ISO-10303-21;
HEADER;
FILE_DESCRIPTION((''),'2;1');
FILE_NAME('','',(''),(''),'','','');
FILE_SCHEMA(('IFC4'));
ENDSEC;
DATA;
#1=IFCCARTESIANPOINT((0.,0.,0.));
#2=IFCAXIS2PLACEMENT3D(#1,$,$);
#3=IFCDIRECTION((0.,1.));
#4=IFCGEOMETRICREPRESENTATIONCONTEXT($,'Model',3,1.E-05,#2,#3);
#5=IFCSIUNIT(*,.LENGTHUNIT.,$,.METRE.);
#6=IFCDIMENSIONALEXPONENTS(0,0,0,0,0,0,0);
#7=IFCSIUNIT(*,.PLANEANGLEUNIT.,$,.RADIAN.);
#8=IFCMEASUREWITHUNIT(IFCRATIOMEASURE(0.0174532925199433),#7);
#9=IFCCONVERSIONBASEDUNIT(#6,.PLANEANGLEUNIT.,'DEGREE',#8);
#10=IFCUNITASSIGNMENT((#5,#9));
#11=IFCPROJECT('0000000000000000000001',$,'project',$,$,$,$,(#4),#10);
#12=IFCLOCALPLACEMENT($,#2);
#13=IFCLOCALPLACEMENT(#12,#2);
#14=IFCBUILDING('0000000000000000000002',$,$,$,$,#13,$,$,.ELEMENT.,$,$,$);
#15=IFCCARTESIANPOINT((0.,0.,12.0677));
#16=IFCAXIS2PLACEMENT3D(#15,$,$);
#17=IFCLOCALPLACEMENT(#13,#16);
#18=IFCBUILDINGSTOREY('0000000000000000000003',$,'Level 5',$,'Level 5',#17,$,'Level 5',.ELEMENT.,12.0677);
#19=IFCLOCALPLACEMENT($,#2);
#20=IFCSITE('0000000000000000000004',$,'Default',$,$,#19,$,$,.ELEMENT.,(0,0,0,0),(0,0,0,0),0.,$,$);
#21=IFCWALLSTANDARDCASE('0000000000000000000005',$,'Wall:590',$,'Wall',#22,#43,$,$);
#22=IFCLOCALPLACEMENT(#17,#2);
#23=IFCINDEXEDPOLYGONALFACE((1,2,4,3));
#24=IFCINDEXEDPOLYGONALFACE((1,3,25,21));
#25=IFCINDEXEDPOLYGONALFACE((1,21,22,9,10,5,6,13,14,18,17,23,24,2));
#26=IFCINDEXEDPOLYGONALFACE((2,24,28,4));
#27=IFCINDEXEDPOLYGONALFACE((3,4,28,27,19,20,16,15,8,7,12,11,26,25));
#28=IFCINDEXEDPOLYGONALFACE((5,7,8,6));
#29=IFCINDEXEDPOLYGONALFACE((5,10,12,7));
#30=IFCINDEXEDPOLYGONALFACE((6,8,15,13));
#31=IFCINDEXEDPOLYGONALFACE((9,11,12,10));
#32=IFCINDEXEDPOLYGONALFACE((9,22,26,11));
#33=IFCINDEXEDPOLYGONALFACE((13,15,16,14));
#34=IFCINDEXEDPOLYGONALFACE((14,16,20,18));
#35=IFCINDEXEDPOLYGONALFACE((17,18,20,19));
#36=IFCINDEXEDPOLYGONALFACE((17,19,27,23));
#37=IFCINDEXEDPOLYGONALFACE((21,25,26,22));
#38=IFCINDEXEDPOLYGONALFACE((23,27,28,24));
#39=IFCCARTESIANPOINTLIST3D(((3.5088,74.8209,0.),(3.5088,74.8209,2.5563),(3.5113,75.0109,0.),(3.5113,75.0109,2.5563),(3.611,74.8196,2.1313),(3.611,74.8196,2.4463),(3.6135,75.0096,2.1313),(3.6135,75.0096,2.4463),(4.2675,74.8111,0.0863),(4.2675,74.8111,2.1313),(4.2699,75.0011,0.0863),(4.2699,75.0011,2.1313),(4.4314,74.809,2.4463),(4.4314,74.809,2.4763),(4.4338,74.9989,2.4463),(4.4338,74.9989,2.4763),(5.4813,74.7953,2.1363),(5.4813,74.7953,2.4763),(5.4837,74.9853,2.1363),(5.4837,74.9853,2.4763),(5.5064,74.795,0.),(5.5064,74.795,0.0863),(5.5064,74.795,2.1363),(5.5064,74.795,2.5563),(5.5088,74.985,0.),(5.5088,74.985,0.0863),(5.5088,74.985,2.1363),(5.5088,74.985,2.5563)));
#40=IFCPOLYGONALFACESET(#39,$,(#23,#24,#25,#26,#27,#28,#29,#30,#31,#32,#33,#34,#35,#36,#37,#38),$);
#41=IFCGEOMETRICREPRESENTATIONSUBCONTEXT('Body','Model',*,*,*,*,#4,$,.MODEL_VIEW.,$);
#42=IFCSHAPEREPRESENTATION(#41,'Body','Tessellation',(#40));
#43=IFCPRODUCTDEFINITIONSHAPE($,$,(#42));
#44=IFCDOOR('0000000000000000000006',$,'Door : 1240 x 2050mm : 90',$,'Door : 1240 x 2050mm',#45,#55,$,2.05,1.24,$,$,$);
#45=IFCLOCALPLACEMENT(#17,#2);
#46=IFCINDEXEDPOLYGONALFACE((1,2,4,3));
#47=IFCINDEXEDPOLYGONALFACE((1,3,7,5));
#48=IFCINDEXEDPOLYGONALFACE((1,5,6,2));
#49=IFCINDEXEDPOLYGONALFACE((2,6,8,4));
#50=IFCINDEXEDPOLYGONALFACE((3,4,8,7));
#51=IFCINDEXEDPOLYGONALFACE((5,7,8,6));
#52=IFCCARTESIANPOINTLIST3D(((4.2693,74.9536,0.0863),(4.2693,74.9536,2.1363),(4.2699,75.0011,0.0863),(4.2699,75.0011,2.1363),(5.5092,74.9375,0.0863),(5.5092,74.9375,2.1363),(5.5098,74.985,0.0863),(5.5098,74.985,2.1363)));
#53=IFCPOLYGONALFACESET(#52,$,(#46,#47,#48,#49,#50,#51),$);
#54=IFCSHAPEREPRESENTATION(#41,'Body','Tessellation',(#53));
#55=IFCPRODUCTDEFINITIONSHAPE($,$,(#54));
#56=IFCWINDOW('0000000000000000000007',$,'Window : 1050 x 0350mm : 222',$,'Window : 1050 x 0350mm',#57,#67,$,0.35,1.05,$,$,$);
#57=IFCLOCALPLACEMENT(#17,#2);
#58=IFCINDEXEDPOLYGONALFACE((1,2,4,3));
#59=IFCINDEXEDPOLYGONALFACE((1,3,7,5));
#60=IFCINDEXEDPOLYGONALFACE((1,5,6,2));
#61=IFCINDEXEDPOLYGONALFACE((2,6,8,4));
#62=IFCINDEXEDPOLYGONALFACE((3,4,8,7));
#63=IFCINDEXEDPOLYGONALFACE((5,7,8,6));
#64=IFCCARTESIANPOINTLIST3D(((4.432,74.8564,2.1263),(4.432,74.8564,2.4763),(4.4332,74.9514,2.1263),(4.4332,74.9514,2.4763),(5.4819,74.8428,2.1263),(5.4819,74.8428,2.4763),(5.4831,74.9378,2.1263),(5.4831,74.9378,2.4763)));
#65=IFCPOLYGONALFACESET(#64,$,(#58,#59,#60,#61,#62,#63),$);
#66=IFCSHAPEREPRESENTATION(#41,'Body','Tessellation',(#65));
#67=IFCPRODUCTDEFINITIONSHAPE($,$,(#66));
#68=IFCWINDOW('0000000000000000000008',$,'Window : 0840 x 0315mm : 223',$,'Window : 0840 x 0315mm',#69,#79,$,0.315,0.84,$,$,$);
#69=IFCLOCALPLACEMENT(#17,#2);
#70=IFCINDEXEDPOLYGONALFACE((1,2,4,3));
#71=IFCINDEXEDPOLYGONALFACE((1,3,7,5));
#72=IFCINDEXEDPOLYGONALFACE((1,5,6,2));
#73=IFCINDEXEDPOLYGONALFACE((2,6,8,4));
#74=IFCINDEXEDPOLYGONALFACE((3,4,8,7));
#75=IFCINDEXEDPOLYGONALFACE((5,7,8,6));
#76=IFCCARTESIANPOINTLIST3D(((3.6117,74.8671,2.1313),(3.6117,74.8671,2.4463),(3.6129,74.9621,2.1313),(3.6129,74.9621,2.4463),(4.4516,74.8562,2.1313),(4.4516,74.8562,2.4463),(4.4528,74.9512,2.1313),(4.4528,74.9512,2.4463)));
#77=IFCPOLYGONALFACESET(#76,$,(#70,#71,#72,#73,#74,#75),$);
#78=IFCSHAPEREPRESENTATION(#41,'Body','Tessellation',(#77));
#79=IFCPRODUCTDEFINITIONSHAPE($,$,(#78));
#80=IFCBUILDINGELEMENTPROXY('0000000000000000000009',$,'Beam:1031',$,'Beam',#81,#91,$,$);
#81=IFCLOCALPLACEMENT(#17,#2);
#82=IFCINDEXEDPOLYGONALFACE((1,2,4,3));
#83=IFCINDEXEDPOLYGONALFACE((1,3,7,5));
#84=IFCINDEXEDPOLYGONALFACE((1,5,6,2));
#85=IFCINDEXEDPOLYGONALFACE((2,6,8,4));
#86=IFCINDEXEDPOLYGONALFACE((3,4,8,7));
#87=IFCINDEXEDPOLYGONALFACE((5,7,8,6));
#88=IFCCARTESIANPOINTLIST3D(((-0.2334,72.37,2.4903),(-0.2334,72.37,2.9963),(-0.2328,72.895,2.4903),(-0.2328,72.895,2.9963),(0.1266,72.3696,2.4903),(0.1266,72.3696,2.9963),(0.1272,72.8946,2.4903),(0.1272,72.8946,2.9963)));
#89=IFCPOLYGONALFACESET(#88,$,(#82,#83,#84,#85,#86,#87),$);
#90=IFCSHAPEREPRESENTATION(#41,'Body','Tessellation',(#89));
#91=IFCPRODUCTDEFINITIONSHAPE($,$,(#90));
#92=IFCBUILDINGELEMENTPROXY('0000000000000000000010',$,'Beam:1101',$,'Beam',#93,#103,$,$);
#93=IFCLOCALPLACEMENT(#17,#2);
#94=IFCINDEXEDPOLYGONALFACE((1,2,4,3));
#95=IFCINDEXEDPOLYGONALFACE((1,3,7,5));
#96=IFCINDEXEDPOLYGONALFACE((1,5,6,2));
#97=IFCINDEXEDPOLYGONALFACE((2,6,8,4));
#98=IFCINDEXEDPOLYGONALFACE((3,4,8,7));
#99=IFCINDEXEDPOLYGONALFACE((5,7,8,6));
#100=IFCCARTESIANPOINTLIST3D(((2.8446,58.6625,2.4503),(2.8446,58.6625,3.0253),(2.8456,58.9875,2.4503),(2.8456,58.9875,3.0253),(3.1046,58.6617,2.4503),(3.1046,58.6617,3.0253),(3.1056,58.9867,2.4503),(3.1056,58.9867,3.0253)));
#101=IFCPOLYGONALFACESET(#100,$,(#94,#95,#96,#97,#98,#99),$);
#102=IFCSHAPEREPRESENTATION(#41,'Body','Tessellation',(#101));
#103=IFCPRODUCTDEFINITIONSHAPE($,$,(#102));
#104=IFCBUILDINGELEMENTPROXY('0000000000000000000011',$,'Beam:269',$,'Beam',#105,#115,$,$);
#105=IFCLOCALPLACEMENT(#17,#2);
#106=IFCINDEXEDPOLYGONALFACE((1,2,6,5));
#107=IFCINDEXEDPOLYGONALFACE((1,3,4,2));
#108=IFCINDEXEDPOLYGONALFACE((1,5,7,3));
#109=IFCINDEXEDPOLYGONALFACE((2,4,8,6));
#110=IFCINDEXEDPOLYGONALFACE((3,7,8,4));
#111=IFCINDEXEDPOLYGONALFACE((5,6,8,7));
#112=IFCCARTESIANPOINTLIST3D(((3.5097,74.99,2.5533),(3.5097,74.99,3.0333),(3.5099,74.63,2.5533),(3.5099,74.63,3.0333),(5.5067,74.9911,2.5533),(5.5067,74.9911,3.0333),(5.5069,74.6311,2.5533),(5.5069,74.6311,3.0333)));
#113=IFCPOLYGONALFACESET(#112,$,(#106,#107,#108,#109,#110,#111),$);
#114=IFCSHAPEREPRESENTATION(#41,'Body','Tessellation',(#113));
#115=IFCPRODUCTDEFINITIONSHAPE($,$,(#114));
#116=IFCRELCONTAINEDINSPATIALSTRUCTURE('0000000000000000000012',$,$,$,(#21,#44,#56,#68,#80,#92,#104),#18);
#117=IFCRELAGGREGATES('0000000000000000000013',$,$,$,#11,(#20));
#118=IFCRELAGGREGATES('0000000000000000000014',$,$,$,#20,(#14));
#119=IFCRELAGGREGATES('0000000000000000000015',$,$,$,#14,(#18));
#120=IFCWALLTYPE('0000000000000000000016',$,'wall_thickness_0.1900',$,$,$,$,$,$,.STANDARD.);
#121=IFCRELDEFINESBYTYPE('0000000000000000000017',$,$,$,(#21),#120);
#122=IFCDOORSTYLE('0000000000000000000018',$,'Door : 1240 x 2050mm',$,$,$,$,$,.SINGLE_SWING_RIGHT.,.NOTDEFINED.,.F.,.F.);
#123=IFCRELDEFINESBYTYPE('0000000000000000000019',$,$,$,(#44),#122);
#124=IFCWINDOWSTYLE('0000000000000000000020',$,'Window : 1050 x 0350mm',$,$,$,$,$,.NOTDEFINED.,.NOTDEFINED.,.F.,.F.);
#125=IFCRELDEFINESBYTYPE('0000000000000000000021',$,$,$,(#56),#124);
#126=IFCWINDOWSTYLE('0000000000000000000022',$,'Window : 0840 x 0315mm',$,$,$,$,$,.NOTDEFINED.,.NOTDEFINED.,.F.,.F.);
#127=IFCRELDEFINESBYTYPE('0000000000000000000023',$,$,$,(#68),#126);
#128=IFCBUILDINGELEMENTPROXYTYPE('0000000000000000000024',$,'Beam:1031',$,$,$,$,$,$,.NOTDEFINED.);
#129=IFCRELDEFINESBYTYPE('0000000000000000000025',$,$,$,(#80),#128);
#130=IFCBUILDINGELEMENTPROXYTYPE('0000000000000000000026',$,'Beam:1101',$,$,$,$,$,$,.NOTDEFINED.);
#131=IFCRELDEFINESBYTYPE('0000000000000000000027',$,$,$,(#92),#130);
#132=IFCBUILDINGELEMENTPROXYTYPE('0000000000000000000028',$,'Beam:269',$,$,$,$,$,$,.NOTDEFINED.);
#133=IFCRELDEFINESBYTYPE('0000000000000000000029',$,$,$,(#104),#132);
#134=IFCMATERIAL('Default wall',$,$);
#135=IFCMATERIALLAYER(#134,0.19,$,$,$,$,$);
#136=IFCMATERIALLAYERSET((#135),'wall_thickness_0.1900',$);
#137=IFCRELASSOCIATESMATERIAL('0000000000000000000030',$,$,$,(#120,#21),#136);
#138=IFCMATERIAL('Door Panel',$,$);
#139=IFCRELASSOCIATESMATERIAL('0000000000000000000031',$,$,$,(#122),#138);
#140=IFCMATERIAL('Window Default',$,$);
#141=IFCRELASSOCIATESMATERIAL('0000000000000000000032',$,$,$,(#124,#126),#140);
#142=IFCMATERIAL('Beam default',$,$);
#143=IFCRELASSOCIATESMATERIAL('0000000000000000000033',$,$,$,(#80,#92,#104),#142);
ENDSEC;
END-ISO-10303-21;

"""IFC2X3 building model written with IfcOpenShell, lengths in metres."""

from ifc_helpers import new_model, entity, si_unit, converted_unit, direction, frame, frame_2d, origin, origin_2d_with_axis, place, context, subcontext, project, spatial, polyline, rectangle, outline, extrude, source, transform, mapped, material, layer, layer_set, layer_usage, type_object, type_shapes, element, fill, save


model = new_model("IFC2X3")

# Units and contexts
model_context = context("Model", 3, precision=1e-05, world=origin(), true_north=direction((0.0, 1.0)))
body_context = subcontext(model_context, "Body", "Model", "MODEL_VIEW")
ifc_project = project(units=[si_unit("LENGTHUNIT", "METRE"), converted_unit("PLANEANGLEUNIT", "DEGREE", entity("IfcRatioMeasure", 0.0174532925199433), si_unit("PLANEANGLEUNIT", "RADIAN"), dimensions=[0, 0, 0, 0, 0, 0, 0])], contexts=[model_context])

# Site, building, storey
site_placement = place(None, origin())
site = spatial("IfcSite", under=ifc_project, at=site_placement, Name="Default", CompositionType="ELEMENT", RefLatitude=(0, 0, 0, 0), RefLongitude=(0, 0, 0, 0), RefElevation=0.0)
placement_1 = place(None, origin())
building_placement = place(placement_1, origin())
building = spatial("IfcBuilding", under=site, at=building_placement, CompositionType="ELEMENT")
storey_placement = place(building_placement, frame((0.0, 0.0, 12.0677)))
storey = spatial("IfcBuildingStorey", under=building, at=storey_placement, Name="Level 5", ObjectType="Level 5", LongName="Level 5", CompositionType="ELEMENT", Elevation=12.0677)

# Shared definitions
ifc_material_1 = material(Name="Default wall")

# Shared definitions
ifc_material_2 = material(Name="Window Default")

# Shared definitions
ifc_material_3 = material(Name="Door Panel")

# Wall, openings, door, windows
ifc_layer_1 = layer(ifc_material_1, 0.19)
ifc_layer_set_1 = layer_set([ifc_layer_1], Name="wall_thickness_0.1900")
ifc_layer_usage_1 = layer_usage(ifc_layer_set_1, "AXIS2", "POSITIVE", -0.095)
wall_type_1 = type_object("IfcWallType", Name="wall_thickness_0.1900", PredefinedType="STANDARD", material=ifc_layer_set_1)
wall_1_placement = place(storey_placement, frame((3.5101, 74.9159, 0.0), z_axis=(0.0, 0.0, 1.0), x_axis=(0.999916, -0.012958, 0.0)))
wall_1 = element("IfcWallStandardCase", 1, at=wall_1_placement, inside=storey, type_object=wall_type_1, material=ifc_layer_usage_1, Name="Wall:590", ObjectType="Wall", context=body_context, shape_type="SweptSolid", body=[
    extrude(outline(polyline([(1.9977, -0.095), (1.9977, 0.095), (0.0, 0.095), (0.0, -0.095), (1.9977, -0.095)])), origin(), (0.0, 0.0, 1.0), 2.5563),
])
opening_1_placement = place(wall_1_placement, frame((0.7587, -0.095, 0.0863)))
opening_1 = element("IfcOpeningElement", 2, at=opening_1_placement, cuts=wall_1, ObjectType="Opening", context=body_context, shape_type="SweptSolid", body=[
    extrude(rectangle(XDim=1.24, YDim=2.05, at=frame_2d((1.025, 0.62), x_axis=(0.0, 1.0))), frame((0.0, 0.0, 0.0), z_axis=(0.0, 1.0, 0.0), x_axis=(0.0, 0.0, 1.0)), (0.0, 0.0, 1.0), 0.19),
])
opening_2_placement = place(wall_1_placement, frame((0.9226, -0.095, 2.1263)))
opening_2 = element("IfcOpeningElement", 3, at=opening_2_placement, cuts=wall_1, ObjectType="Opening", context=body_context, shape_type="SweptSolid", body=[
    extrude(rectangle(XDim=1.05, YDim=0.35, at=frame_2d((0.175, 0.525), x_axis=(0.0, 1.0))), frame((0.0, 0.0, 0.0), z_axis=(0.0, 1.0, 0.0), x_axis=(0.0, 0.0, 1.0)), (0.0, 0.0, 1.0), 0.19),
])
opening_3_placement = place(wall_1_placement, frame((0.1022, -0.095, 2.1313)))
opening_3 = element("IfcOpeningElement", 4, at=opening_3_placement, cuts=wall_1, ObjectType="Opening", context=body_context, shape_type="SweptSolid", body=[
    extrude(rectangle(XDim=0.84, YDim=0.315, at=frame_2d((0.1575, 0.42), x_axis=(0.0, 1.0))), frame((0.0, 0.0, 0.0), z_axis=(0.0, 1.0, 0.0), x_axis=(0.0, 0.0, 1.0)), (0.0, 0.0, 1.0), 0.19),
])
door_style_1 = type_object("IfcDoorStyle", Name="Door : 1240 x 2050mm", ConstructionType="NOTDEFINED", OperationType="SINGLE_SWING_RIGHT", ParameterTakesPrecedence=False, Sizeable=False, material=ifc_material_3)
shared_shape_1 = source(origin(), body_context, "Body", "SweptSolid", [
    extrude(rectangle(XDim=0.0475, YDim=1.24, at=origin_2d_with_axis()), frame((0.62, 0.1662, 0.0), z_axis=(0.0, 0.0, 1.0), x_axis=(0.0, 1.0, 0.0)), (0.0, 0.0, 1.0), 2.05),
])
type_shapes(door_style_1, [shared_shape_1])
door_1_placement = place(opening_1_placement, origin())
door_1 = element("IfcDoor", 5, at=door_1_placement, inside=storey, type_object=door_style_1, Name="Door : 1240 x 2050mm : 90", ObjectType="Door : 1240 x 2050mm", OverallHeight=2.05, OverallWidth=1.24, context=body_context, shape_type="MappedRepresentation", body=[
    mapped(shared_shape_1, transform((0.0, 0.0, 0.0), scale=1.0)),
])
fill(opening_1, door_1)
window_style_1 = type_object("IfcWindowStyle", Name="Window : 1050 x 0350mm", ConstructionType="NOTDEFINED", OperationType="NOTDEFINED", ParameterTakesPrecedence=False, Sizeable=False, material=ifc_material_2)
shared_shape_2 = source(origin(), body_context, "Body", "SweptSolid", [
    extrude(rectangle(XDim=0.095, YDim=1.05, at=origin_2d_with_axis()), frame((0.525, 0.095, 0.0), z_axis=(0.0, 0.0, 1.0), x_axis=(0.0, 1.0, 0.0)), (0.0, 0.0, 1.0), 0.35),
])
type_shapes(window_style_1, [shared_shape_2])
window_1_placement = place(opening_2_placement, origin())
window_1 = element("IfcWindow", 6, at=window_1_placement, inside=storey, type_object=window_style_1, Name="Window : 1050 x 0350mm : 222", ObjectType="Window : 1050 x 0350mm", OverallHeight=0.35, OverallWidth=1.05, context=body_context, shape_type="MappedRepresentation", body=[
    mapped(shared_shape_2, transform((0.0, 0.0, 0.0), scale=1.0)),
])
fill(opening_2, window_1)
window_style_2 = type_object("IfcWindowStyle", Name="Window : 0840 x 0315mm", ConstructionType="NOTDEFINED", OperationType="NOTDEFINED", ParameterTakesPrecedence=False, Sizeable=False, material=ifc_material_2)
shared_shape_3 = source(origin(), body_context, "Body", "SweptSolid", [
    extrude(rectangle(XDim=0.095, YDim=0.84, at=origin_2d_with_axis()), frame((0.42, 0.095, 0.0), z_axis=(0.0, 0.0, 1.0), x_axis=(0.0, 1.0, 0.0)), (0.0, 0.0, 1.0), 0.315),
])
type_shapes(window_style_2, [shared_shape_3])
window_2_placement = place(opening_3_placement, origin())
window_2 = element("IfcWindow", 7, at=window_2_placement, inside=storey, type_object=window_style_2, Name="Window : 0840 x 0315mm : 223", ObjectType="Window : 0840 x 0315mm", OverallHeight=0.315, OverallWidth=0.84, context=body_context, shape_type="MappedRepresentation", body=[
    mapped(shared_shape_3, transform((0.0, 0.0, 0.0), scale=1.0)),
])
fill(opening_3, window_2)

# Building element proxies
ifc_material_4 = material(Name="Beam default")
building_element_proxy_type_1 = type_object("IfcBuildingElementProxyType", Name="Beam:1031", PredefinedType="NOTDEFINED")
shared_shape_4 = source(origin(), body_context, "Body", "SweptSolid", [
    extrude(outline(polyline([(0.525, -0.18), (0.525, 0.18), (0.0, 0.18), (0.0, -0.18), (0.525, -0.18)])), origin(), (0.0, 0.0, 1.0), 0.506),
])
type_shapes(building_element_proxy_type_1, [shared_shape_4])
placement_2 = place(building_placement, frame((0.0, 0.0, 14.558)))
proxy_1_placement = place(placement_2, frame((-0.0528, 72.8948, 0.0), z_axis=(0.0, 0.0, 1.0), x_axis=(-0.001112, -0.999999, 0.0)))
element("IfcBuildingElementProxy", 8, at=proxy_1_placement, inside=storey, type_object=building_element_proxy_type_1, material=ifc_material_4, Name="Beam:1031", ObjectType="Beam", context=body_context, shape_type="MappedRepresentation", body=[
    mapped(shared_shape_4, transform((0.0, 0.0, 0.0), scale=1.0)),
])
building_element_proxy_type_2 = type_object("IfcBuildingElementProxyType", Name="Beam:1101", PredefinedType="NOTDEFINED")
shared_shape_5 = source(origin(), body_context, "Body", "SweptSolid", [
    extrude(outline(polyline([(0.325, -0.13), (0.325, 0.13), (0.0, 0.13), (0.0, -0.13), (0.325, -0.13)])), origin(), (0.0, 0.0, 1.0), 0.575),
])
type_shapes(building_element_proxy_type_2, [shared_shape_5])
placement_3 = place(building_placement, frame((0.0, 0.0, 14.518)))
proxy_2_placement = place(placement_3, frame((2.9756, 58.9871, 0.0), z_axis=(0.0, 0.0, 1.0), x_axis=(-0.003112, -0.999995, 0.0)))
element("IfcBuildingElementProxy", 9, at=proxy_2_placement, inside=storey, type_object=building_element_proxy_type_2, material=ifc_material_4, Name="Beam:1101", ObjectType="Beam", context=body_context, shape_type="MappedRepresentation", body=[
    mapped(shared_shape_5, transform((0.0, 0.0, 0.0), scale=1.0)),
])
building_element_proxy_type_3 = type_object("IfcBuildingElementProxyType", Name="Beam:269", PredefinedType="NOTDEFINED")
shared_shape_6 = source(origin(), body_context, "Body", "SweptSolid", [
    extrude(outline(polyline([(1.9969, -0.18), (1.9969, 0.18), (0.0, 0.18), (0.0, -0.18), (1.9969, -0.18)])), origin(), (0.0, 0.0, 1.0), 0.48),
])
type_shapes(building_element_proxy_type_3, [shared_shape_6])
placement_4 = place(building_placement, frame((0.0, 0.0, 14.621)))
proxy_3_placement = place(placement_4, frame((3.5098, 74.81, 0.0), z_axis=(0.0, 0.0, 1.0), x_axis=(1.0, 0.000535, 0.0)))
element("IfcBuildingElementProxy", 10, at=proxy_3_placement, inside=storey, type_object=building_element_proxy_type_3, material=ifc_material_4, Name="Beam:269", ObjectType="Beam", context=body_context, shape_type="MappedRepresentation", body=[
    mapped(shared_shape_6, transform((0.0, 0.0, 0.0), scale=1.0)),
])

save(model, "model.ifc")
